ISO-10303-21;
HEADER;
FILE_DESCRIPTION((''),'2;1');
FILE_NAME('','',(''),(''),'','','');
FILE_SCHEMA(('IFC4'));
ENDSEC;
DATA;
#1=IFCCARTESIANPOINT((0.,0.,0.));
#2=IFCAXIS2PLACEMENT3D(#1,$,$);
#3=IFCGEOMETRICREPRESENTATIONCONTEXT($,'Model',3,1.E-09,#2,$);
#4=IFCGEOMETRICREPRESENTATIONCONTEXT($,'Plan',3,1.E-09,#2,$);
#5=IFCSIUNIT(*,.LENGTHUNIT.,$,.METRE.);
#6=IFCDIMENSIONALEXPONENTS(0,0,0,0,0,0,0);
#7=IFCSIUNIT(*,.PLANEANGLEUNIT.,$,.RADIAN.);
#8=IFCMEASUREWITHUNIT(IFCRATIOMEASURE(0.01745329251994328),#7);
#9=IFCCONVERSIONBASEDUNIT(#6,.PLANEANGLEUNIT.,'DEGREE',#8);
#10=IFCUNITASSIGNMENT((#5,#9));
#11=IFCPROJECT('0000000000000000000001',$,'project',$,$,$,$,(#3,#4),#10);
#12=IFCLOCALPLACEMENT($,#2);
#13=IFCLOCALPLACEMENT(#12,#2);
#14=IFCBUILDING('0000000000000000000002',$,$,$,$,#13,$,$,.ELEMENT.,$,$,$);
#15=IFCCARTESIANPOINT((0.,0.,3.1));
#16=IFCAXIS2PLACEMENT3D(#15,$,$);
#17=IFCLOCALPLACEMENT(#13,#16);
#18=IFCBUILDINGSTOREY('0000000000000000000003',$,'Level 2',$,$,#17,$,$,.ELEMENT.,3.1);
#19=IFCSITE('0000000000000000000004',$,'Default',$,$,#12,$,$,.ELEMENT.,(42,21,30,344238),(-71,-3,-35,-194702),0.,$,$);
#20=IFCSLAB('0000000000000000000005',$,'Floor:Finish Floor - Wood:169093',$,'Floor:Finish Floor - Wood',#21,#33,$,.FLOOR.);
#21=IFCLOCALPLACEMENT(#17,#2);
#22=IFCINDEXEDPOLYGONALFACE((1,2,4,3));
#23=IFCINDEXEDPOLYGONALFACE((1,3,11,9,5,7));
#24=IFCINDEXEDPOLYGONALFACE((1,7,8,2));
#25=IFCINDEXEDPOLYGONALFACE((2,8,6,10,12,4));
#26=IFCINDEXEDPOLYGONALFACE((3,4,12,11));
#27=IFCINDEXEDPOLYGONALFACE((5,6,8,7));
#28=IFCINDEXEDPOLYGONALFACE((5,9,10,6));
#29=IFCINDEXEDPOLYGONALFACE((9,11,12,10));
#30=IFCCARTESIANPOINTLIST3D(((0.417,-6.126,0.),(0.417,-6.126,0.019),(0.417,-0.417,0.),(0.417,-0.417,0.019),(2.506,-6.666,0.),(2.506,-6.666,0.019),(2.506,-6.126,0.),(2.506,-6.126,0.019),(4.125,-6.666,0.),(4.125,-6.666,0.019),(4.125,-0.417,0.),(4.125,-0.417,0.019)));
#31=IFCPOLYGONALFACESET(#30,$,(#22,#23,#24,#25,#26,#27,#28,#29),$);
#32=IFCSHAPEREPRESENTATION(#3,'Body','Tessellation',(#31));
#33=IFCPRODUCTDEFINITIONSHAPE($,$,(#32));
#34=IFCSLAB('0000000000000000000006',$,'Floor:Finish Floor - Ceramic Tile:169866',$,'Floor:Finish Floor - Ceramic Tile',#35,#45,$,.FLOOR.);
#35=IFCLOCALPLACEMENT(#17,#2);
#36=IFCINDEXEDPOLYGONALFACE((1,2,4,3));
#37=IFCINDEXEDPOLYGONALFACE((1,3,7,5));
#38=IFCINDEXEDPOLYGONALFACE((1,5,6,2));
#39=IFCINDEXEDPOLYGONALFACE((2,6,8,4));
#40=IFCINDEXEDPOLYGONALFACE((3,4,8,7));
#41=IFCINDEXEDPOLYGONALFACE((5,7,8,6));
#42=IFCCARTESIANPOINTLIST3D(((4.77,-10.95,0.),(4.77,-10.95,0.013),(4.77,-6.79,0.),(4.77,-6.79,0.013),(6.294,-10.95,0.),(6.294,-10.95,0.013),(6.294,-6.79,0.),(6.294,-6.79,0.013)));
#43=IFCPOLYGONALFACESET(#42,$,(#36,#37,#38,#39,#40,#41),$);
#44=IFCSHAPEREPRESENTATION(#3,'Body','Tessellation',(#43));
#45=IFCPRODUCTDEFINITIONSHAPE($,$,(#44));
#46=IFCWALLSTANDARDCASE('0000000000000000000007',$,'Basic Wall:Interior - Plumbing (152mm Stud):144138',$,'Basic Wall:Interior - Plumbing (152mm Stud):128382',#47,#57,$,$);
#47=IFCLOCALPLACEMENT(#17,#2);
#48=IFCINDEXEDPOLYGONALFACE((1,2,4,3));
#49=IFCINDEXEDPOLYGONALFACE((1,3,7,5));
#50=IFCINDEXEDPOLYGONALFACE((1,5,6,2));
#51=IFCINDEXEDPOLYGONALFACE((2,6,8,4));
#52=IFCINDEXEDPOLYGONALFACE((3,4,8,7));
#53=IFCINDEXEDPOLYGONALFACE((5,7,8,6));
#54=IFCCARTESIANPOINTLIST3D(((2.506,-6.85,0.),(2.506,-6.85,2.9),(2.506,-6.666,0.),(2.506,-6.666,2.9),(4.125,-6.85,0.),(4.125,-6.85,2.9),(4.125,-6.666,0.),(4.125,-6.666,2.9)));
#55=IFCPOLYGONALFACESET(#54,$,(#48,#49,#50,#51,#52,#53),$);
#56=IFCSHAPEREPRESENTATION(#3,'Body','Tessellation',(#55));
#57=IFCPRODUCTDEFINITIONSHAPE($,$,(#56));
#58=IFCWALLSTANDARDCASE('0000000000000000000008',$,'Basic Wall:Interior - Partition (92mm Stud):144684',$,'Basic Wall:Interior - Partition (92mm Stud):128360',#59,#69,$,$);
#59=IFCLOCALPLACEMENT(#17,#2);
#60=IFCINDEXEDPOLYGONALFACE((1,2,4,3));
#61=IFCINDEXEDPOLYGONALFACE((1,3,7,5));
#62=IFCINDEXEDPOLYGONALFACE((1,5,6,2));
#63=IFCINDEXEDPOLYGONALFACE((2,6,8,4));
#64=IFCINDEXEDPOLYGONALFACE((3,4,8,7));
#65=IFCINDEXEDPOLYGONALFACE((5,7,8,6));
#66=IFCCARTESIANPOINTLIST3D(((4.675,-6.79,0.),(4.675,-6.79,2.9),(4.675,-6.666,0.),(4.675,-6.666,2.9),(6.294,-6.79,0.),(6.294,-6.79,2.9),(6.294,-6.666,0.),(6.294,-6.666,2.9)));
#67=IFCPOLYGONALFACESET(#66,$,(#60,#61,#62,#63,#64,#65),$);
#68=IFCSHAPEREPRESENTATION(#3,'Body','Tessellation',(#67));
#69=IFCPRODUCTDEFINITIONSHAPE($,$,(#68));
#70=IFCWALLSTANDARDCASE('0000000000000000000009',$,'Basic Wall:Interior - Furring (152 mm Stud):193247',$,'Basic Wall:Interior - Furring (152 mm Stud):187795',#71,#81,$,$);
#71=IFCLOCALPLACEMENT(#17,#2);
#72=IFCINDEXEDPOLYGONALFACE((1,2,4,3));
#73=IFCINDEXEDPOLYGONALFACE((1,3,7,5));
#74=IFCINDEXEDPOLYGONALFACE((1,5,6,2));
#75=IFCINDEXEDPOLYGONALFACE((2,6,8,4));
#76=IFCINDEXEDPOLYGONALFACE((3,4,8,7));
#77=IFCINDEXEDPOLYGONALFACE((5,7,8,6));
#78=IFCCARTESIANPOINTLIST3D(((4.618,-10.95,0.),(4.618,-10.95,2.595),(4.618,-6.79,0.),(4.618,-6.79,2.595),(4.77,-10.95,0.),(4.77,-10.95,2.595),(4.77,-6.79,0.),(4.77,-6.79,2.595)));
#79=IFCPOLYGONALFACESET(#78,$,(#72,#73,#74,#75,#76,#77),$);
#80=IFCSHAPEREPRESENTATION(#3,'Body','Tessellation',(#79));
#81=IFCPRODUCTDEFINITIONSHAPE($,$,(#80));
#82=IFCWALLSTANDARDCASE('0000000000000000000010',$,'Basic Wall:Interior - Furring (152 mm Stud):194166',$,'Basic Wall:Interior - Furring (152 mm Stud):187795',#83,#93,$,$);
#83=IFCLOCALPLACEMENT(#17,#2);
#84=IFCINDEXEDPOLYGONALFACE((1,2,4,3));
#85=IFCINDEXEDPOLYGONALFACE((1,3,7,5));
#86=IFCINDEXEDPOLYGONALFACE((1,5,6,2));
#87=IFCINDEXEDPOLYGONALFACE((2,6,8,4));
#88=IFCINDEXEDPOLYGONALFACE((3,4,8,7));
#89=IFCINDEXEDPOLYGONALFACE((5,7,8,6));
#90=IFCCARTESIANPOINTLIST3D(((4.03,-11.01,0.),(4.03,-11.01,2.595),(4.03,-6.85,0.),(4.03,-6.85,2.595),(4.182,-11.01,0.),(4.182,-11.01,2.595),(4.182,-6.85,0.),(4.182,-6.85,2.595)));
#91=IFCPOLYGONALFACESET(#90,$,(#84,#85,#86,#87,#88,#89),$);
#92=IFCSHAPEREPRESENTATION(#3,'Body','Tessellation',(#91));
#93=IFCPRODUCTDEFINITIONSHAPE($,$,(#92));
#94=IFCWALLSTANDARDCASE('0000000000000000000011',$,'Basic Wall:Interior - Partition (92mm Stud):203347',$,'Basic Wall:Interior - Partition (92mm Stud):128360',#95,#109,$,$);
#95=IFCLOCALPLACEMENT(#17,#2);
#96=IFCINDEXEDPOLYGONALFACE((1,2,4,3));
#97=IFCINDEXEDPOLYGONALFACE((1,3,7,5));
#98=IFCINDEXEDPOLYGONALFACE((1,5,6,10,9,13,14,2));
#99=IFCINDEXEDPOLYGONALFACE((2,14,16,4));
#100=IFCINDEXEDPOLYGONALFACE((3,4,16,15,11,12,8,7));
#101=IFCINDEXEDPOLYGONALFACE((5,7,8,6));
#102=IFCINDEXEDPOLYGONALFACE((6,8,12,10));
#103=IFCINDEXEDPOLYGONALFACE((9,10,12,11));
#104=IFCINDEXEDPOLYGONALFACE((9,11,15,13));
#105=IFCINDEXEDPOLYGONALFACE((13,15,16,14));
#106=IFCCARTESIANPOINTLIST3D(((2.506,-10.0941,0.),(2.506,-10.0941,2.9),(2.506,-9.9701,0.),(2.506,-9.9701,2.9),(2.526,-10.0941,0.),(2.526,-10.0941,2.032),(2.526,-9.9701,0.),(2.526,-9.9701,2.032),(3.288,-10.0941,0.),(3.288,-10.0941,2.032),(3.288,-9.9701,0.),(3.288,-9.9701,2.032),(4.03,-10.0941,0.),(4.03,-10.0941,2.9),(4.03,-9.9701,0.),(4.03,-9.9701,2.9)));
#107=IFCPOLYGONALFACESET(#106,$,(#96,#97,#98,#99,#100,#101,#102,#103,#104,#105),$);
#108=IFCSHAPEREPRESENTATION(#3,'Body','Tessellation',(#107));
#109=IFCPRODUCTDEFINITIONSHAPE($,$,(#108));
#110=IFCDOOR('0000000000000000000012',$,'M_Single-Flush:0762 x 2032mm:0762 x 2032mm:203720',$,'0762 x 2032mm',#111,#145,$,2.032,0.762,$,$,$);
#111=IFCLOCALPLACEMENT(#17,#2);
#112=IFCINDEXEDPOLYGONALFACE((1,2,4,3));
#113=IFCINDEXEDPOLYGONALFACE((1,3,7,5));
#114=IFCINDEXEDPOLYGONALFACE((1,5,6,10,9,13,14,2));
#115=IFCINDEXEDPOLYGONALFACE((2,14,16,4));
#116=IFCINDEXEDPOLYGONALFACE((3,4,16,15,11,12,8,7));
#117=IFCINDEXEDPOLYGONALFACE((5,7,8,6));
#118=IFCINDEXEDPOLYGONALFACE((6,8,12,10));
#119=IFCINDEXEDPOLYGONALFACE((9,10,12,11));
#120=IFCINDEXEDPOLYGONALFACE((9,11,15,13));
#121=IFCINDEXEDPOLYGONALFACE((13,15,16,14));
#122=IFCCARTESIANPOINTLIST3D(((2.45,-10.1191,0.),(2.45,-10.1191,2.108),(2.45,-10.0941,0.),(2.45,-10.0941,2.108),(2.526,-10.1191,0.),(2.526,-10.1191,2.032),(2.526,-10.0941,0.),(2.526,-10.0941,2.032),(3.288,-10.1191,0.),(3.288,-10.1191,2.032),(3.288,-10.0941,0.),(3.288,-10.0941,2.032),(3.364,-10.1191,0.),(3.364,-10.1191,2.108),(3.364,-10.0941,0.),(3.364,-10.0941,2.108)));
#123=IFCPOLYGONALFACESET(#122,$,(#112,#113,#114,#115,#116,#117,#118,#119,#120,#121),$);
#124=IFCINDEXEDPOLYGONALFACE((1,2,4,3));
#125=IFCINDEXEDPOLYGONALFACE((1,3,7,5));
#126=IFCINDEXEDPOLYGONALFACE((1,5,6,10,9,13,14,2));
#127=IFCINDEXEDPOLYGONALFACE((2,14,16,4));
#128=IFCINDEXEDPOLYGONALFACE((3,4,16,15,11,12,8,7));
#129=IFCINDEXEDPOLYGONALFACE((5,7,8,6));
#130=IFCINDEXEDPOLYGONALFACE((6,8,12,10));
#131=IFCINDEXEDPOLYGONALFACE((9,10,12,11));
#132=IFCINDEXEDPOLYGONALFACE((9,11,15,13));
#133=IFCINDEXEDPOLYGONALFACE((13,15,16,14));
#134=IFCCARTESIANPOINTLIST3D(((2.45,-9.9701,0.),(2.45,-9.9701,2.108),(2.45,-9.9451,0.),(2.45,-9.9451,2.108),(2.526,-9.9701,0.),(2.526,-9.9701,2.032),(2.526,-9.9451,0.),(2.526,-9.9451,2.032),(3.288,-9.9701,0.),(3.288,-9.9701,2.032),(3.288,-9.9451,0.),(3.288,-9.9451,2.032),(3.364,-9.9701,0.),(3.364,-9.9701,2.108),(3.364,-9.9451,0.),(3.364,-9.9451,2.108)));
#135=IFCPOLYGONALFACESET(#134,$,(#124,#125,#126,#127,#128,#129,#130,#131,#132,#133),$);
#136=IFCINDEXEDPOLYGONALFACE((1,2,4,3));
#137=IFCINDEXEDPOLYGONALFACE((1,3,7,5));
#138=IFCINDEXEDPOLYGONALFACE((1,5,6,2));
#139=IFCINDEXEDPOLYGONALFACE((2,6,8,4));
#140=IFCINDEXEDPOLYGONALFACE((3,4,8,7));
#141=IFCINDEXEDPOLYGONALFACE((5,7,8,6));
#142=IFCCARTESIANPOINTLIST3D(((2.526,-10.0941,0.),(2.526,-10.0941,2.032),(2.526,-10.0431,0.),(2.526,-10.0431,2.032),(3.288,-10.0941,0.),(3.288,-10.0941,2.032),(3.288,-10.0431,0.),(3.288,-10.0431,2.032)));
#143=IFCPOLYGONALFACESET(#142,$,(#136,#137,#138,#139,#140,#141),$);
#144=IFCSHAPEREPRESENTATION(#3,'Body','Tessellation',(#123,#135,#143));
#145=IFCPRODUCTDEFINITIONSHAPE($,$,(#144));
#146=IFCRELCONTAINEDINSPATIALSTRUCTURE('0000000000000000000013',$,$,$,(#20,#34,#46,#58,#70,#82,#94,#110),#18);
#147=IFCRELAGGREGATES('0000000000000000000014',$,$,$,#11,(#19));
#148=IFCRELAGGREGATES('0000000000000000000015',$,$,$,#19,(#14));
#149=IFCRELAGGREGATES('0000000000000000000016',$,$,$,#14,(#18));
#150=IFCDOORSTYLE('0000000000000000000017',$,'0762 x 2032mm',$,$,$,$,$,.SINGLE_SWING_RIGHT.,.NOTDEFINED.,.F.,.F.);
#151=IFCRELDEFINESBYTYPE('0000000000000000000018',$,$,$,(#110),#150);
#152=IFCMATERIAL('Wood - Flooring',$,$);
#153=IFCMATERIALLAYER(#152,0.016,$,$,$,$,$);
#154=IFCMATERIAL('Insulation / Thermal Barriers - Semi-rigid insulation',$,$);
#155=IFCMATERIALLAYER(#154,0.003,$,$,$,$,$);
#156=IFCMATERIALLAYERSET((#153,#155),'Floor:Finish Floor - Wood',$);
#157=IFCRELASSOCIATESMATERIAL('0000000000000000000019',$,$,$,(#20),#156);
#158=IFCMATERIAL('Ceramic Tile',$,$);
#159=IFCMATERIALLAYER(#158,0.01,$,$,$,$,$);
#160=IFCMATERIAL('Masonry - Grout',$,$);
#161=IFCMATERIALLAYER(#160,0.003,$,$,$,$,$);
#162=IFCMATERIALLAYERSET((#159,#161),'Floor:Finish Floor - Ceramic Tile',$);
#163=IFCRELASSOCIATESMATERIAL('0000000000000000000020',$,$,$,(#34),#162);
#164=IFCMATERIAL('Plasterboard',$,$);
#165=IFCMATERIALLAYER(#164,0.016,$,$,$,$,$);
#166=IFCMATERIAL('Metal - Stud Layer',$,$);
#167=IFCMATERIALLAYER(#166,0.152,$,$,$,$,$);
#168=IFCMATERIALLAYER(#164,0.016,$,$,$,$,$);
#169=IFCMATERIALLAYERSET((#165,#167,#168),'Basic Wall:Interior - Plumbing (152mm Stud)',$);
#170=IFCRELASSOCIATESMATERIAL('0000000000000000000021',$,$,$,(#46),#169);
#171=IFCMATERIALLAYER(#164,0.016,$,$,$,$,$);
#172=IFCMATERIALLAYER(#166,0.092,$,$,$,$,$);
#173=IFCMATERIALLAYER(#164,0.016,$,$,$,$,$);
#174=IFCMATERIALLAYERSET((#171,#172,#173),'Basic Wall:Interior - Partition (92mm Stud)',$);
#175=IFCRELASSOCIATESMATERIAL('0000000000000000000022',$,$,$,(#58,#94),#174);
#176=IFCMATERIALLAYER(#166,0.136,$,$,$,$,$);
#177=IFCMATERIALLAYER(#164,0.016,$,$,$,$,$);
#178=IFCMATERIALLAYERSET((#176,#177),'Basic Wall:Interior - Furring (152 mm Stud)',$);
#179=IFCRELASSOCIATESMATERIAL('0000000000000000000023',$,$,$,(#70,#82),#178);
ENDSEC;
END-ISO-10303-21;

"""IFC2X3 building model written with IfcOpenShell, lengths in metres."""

from ifc_helpers import new_model, entity, si_unit, converted_unit, frame, frame_2d, origin, origin_2d_with_axis, place, context, project, spatial, polyline, rectangle, outline, extrude, source, transform, mapped, material, layer, layer_set, layer_usage, type_object, type_shapes, element, fill, save


model = new_model("IFC2X3")

# Units and contexts
model_context = context("Model", 3, precision=1e-09, world=origin())
plan_context = context("Plan", 3, precision=1e-09, world=origin())
ifc_project = project(units=[si_unit("LENGTHUNIT", "METRE"), converted_unit("PLANEANGLEUNIT", "DEGREE", entity("IfcRatioMeasure", 0.01745329251994328), si_unit("PLANEANGLEUNIT", "RADIAN"), dimensions=[0, 0, 0, 0, 0, 0, 0])], contexts=[model_context, plan_context])

# Site, building, storey
site_placement = place(None, origin())
site = spatial("IfcSite", under=ifc_project, at=site_placement, Name="Default", CompositionType="ELEMENT", RefLatitude=(42, 21, 30, 344238), RefLongitude=(-71, -3, -35, -194702), RefElevation=0.0)
building_placement = place(site_placement, origin())
building = spatial("IfcBuilding", under=site, at=building_placement, CompositionType="ELEMENT")
storey_placement = place(building_placement, frame((0.0, 0.0, 3.1)))
storey = spatial("IfcBuildingStorey", under=building, at=storey_placement, Name="Level 2", CompositionType="ELEMENT", Elevation=3.1)

# Slabs
ifc_material_1 = material(Name="Wood - Flooring")
ifc_layer_1 = layer(ifc_material_1, 0.016)
ifc_material_2 = material(Name="Insulation / Thermal Barriers - Semi-rigid insulation")
ifc_layer_2 = layer(ifc_material_2, 0.003)
ifc_layer_set_1 = layer_set([ifc_layer_1, ifc_layer_2], Name="Floor:Finish Floor - Wood")
ifc_layer_usage_1 = layer_usage(ifc_layer_set_1, "AXIS3", "POSITIVE", 0.0)
slab_1_placement = place(storey_placement, frame((0.417, -6.666, 0.0)))
element("IfcSlab", 1, at=slab_1_placement, inside=storey, material=ifc_layer_usage_1, Name="Floor:Finish Floor - Wood:169093", ObjectType="Floor:Finish Floor - Wood", PredefinedType="FLOOR", context=model_context, shape_type="SweptSolid", body=[
    extrude(outline(polyline([(1.854, 3.1245), (-1.854, 3.1245), (-1.854, -3.1245), (-0.235, -3.1245), (-0.235, -2.5845), (1.854, -2.5845), (1.854, 3.1245)])), frame((1.854, 3.1245, 0.019), z_axis=(0.0, 0.0, -1.0), x_axis=(-1.0, 0.0, 0.0)), (0.0, 0.0, 1.0), 0.019),
])
ifc_material_3 = material(Name="Ceramic Tile")
ifc_layer_3 = layer(ifc_material_3, 0.01)
ifc_material_4 = material(Name="Masonry - Grout")
ifc_layer_4 = layer(ifc_material_4, 0.003)
ifc_layer_set_2 = layer_set([ifc_layer_3, ifc_layer_4], Name="Floor:Finish Floor - Ceramic Tile")
ifc_layer_usage_2 = layer_usage(ifc_layer_set_2, "AXIS3", "POSITIVE", 0.0)
slab_2_placement = place(storey_placement, frame((4.77, -10.95, 0.0)))
element("IfcSlab", 2, at=slab_2_placement, inside=storey, material=ifc_layer_usage_2, Name="Floor:Finish Floor - Ceramic Tile:169866", ObjectType="Floor:Finish Floor - Ceramic Tile", PredefinedType="FLOOR", context=model_context, shape_type="SweptSolid", body=[
    extrude(rectangle(XDim=4.16, YDim=1.524, at=frame_2d((0.0, 0.0), x_axis=(0.0, -1.0))), frame((0.762, 2.08, 0.013), z_axis=(0.0, 0.0, -1.0), x_axis=(-1.0, 0.0, 0.0)), (0.0, 0.0, 1.0), 0.013),
])

# Walls
ifc_material_5 = material(Name="Plasterboard")
ifc_layer_5 = layer(ifc_material_5, 0.016)
ifc_material_6 = material(Name="Metal - Stud Layer")
ifc_layer_6 = layer(ifc_material_6, 0.152)
ifc_layer_7 = layer(ifc_material_5, 0.016)
ifc_layer_set_3 = layer_set([ifc_layer_5, ifc_layer_6, ifc_layer_7], Name="Basic Wall:Interior - Plumbing (152mm Stud)")
ifc_layer_usage_3 = layer_usage(ifc_layer_set_3, "AXIS2", "NEGATIVE", 0.092)
wall_1_placement = place(storey_placement, frame((2.506, -6.758, 0.0)))
element("IfcWallStandardCase", 3, at=wall_1_placement, inside=storey, material=ifc_layer_usage_3, Name="Basic Wall:Interior - Plumbing (152mm Stud):144138", ObjectType="Basic Wall:Interior - Plumbing (152mm Stud):128382", context=model_context, shape_type="SweptSolid", body=[
    extrude(rectangle(XDim=1.619, YDim=0.184, at=frame_2d((0.8095, 0.0), x_axis=(-1.0, 0.0))), origin(), (0.0, 0.0, 1.0), 2.9),
])
ifc_layer_8 = layer(ifc_material_5, 0.016)
ifc_layer_9 = layer(ifc_material_6, 0.092)
ifc_layer_10 = layer(ifc_material_5, 0.016)
ifc_layer_set_4 = layer_set([ifc_layer_8, ifc_layer_9, ifc_layer_10], Name="Basic Wall:Interior - Partition (92mm Stud)")
ifc_layer_usage_4 = layer_usage(ifc_layer_set_4, "AXIS2", "NEGATIVE", 0.062)
wall_2_placement = place(storey_placement, frame((4.675, -6.728, 0.0)))
element("IfcWallStandardCase", 4, at=wall_2_placement, inside=storey, material=ifc_layer_usage_4, Name="Basic Wall:Interior - Partition (92mm Stud):144684", ObjectType="Basic Wall:Interior - Partition (92mm Stud):128360", context=model_context, shape_type="SweptSolid", body=[
    extrude(rectangle(XDim=1.619, YDim=0.124, at=frame_2d((0.8095, 0.0), x_axis=(-1.0, 0.0))), origin(), (0.0, 0.0, 1.0), 2.9),
])
ifc_layer_11 = layer(ifc_material_6, 0.136)
ifc_layer_12 = layer(ifc_material_5, 0.016)
ifc_layer_set_5 = layer_set([ifc_layer_11, ifc_layer_12], Name="Basic Wall:Interior - Furring (152 mm Stud)")
ifc_layer_usage_5 = layer_usage(ifc_layer_set_5, "AXIS2", "POSITIVE", -0.076)
wall_3_placement = place(storey_placement, frame((4.694, -6.79, 0.0), z_axis=(0.0, 0.0, 1.0), x_axis=(0.0, -1.0, 0.0)))
element("IfcWallStandardCase", 5, at=wall_3_placement, inside=storey, material=ifc_layer_usage_5, Name="Basic Wall:Interior - Furring (152 mm Stud):193247", ObjectType="Basic Wall:Interior - Furring (152 mm Stud):187795", context=model_context, shape_type="SweptSolid", body=[
    extrude(rectangle(XDim=4.16, YDim=0.152, at=frame_2d((2.08, 0.0), x_axis=(-1.0, 0.0))), origin(), (0.0, 0.0, 1.0), 2.595),
])
ifc_layer_usage_6 = layer_usage(ifc_layer_set_5, "AXIS2", "POSITIVE", -0.076)
wall_4_placement = place(storey_placement, frame((4.106, -11.01, 0.0), z_axis=(0.0, 0.0, 1.0), x_axis=(0.0, 1.0, 0.0)))
element("IfcWallStandardCase", 6, at=wall_4_placement, inside=storey, material=ifc_layer_usage_6, Name="Basic Wall:Interior - Furring (152 mm Stud):194166", ObjectType="Basic Wall:Interior - Furring (152 mm Stud):187795", context=model_context, shape_type="SweptSolid", body=[
    extrude(rectangle(XDim=4.16, YDim=0.152, at=frame_2d((2.08, 0.0), x_axis=(-1.0, 0.0))), origin(), (0.0, 0.0, 1.0), 2.595),
])

# Wall, opening, door
ifc_layer_usage_7 = layer_usage(ifc_layer_set_4, "AXIS2", "NEGATIVE", 0.062)
wall_5_placement = place(storey_placement, frame((4.03, -10.0321, 0.0), z_axis=(0.0, 0.0, 1.0), x_axis=(-1.0, 0.0, 0.0)))
wall_5 = element("IfcWallStandardCase", 7, at=wall_5_placement, inside=storey, material=ifc_layer_usage_7, Name="Basic Wall:Interior - Partition (92mm Stud):203347", ObjectType="Basic Wall:Interior - Partition (92mm Stud):128360", context=model_context, shape_type="SweptSolid", body=[
    extrude(rectangle(XDim=1.524, YDim=0.124, at=frame_2d((0.762, 0.0), x_axis=(-1.0, 0.0))), origin(), (0.0, 0.0, 1.0), 2.9),
])
opening_1_placement = place(wall_5_placement, frame((0.742, -0.062, 0.0)))
opening_1 = element("IfcOpeningElement", 8, at=opening_1_placement, cuts=wall_5, ObjectType="Opening", context=model_context, shape_type="SweptSolid", body=[
    extrude(rectangle(XDim=0.762, YDim=2.032, at=frame_2d((1.016, 0.381), x_axis=(0.0, 1.0))), frame((0.0, 0.0, 0.0), z_axis=(0.0, 1.0, 0.0), x_axis=(0.0, 0.0, 1.0)), (0.0, 0.0, 1.0), 0.124),
])
door_style = type_object("IfcDoorStyle", Name="0762 x 2032mm", ConstructionType="NOTDEFINED", OperationType="SINGLE_SWING_RIGHT", ParameterTakesPrecedence=False, Sizeable=False)
shared_shape = source(origin(), model_context, "Body", "SweptSolid", [
    extrude(outline(polyline([(-0.457, -1.073), (0.457, -1.073), (0.457, 1.035), (0.381, 1.035), (0.381, -0.997), (-0.381, -0.997), (-0.381, 1.035), (-0.457, 1.035), (-0.457, -1.073)])), frame((0.381, 0.124, 1.035), z_axis=(0.0, 1.0, 0.0), x_axis=(1.0, 0.0, 0.0)), (0.0, 0.0, 1.0), 0.025),
    extrude(outline(polyline([(-1.073, -0.457), (1.035, -0.457), (1.035, -0.381), (-0.997, -0.381), (-0.997, 0.381), (1.035, 0.381), (1.035, 0.457), (-1.073, 0.457), (-1.073, -0.457)])), frame((0.381, -0.025, 1.035), z_axis=(0.0, 1.0, 0.0), x_axis=(0.0, 0.0, -1.0)), (0.0, 0.0, 1.0), 0.025),
    extrude(rectangle(XDim=0.051, YDim=0.762, at=origin_2d_with_axis()), frame((0.381, 0.0985, 0.0), z_axis=(0.0, 0.0, 1.0), x_axis=(0.0, 1.0, 0.0)), (0.0, 0.0, 1.0), 2.032),
])
type_shapes(door_style, [shared_shape])
door_1_placement = place(opening_1_placement, origin())
door_1 = element("IfcDoor", 9, at=door_1_placement, inside=storey, type_object=door_style, Name="M_Single-Flush:0762 x 2032mm:0762 x 2032mm:203720", ObjectType="0762 x 2032mm", OverallHeight=2.032, OverallWidth=0.762, context=model_context, shape_type="MappedRepresentation", body=[
    mapped(shared_shape, transform((0.0, 0.0, 0.0), scale=1.0)),
])
fill(opening_1, door_1)

save(model, "model.ifc")
